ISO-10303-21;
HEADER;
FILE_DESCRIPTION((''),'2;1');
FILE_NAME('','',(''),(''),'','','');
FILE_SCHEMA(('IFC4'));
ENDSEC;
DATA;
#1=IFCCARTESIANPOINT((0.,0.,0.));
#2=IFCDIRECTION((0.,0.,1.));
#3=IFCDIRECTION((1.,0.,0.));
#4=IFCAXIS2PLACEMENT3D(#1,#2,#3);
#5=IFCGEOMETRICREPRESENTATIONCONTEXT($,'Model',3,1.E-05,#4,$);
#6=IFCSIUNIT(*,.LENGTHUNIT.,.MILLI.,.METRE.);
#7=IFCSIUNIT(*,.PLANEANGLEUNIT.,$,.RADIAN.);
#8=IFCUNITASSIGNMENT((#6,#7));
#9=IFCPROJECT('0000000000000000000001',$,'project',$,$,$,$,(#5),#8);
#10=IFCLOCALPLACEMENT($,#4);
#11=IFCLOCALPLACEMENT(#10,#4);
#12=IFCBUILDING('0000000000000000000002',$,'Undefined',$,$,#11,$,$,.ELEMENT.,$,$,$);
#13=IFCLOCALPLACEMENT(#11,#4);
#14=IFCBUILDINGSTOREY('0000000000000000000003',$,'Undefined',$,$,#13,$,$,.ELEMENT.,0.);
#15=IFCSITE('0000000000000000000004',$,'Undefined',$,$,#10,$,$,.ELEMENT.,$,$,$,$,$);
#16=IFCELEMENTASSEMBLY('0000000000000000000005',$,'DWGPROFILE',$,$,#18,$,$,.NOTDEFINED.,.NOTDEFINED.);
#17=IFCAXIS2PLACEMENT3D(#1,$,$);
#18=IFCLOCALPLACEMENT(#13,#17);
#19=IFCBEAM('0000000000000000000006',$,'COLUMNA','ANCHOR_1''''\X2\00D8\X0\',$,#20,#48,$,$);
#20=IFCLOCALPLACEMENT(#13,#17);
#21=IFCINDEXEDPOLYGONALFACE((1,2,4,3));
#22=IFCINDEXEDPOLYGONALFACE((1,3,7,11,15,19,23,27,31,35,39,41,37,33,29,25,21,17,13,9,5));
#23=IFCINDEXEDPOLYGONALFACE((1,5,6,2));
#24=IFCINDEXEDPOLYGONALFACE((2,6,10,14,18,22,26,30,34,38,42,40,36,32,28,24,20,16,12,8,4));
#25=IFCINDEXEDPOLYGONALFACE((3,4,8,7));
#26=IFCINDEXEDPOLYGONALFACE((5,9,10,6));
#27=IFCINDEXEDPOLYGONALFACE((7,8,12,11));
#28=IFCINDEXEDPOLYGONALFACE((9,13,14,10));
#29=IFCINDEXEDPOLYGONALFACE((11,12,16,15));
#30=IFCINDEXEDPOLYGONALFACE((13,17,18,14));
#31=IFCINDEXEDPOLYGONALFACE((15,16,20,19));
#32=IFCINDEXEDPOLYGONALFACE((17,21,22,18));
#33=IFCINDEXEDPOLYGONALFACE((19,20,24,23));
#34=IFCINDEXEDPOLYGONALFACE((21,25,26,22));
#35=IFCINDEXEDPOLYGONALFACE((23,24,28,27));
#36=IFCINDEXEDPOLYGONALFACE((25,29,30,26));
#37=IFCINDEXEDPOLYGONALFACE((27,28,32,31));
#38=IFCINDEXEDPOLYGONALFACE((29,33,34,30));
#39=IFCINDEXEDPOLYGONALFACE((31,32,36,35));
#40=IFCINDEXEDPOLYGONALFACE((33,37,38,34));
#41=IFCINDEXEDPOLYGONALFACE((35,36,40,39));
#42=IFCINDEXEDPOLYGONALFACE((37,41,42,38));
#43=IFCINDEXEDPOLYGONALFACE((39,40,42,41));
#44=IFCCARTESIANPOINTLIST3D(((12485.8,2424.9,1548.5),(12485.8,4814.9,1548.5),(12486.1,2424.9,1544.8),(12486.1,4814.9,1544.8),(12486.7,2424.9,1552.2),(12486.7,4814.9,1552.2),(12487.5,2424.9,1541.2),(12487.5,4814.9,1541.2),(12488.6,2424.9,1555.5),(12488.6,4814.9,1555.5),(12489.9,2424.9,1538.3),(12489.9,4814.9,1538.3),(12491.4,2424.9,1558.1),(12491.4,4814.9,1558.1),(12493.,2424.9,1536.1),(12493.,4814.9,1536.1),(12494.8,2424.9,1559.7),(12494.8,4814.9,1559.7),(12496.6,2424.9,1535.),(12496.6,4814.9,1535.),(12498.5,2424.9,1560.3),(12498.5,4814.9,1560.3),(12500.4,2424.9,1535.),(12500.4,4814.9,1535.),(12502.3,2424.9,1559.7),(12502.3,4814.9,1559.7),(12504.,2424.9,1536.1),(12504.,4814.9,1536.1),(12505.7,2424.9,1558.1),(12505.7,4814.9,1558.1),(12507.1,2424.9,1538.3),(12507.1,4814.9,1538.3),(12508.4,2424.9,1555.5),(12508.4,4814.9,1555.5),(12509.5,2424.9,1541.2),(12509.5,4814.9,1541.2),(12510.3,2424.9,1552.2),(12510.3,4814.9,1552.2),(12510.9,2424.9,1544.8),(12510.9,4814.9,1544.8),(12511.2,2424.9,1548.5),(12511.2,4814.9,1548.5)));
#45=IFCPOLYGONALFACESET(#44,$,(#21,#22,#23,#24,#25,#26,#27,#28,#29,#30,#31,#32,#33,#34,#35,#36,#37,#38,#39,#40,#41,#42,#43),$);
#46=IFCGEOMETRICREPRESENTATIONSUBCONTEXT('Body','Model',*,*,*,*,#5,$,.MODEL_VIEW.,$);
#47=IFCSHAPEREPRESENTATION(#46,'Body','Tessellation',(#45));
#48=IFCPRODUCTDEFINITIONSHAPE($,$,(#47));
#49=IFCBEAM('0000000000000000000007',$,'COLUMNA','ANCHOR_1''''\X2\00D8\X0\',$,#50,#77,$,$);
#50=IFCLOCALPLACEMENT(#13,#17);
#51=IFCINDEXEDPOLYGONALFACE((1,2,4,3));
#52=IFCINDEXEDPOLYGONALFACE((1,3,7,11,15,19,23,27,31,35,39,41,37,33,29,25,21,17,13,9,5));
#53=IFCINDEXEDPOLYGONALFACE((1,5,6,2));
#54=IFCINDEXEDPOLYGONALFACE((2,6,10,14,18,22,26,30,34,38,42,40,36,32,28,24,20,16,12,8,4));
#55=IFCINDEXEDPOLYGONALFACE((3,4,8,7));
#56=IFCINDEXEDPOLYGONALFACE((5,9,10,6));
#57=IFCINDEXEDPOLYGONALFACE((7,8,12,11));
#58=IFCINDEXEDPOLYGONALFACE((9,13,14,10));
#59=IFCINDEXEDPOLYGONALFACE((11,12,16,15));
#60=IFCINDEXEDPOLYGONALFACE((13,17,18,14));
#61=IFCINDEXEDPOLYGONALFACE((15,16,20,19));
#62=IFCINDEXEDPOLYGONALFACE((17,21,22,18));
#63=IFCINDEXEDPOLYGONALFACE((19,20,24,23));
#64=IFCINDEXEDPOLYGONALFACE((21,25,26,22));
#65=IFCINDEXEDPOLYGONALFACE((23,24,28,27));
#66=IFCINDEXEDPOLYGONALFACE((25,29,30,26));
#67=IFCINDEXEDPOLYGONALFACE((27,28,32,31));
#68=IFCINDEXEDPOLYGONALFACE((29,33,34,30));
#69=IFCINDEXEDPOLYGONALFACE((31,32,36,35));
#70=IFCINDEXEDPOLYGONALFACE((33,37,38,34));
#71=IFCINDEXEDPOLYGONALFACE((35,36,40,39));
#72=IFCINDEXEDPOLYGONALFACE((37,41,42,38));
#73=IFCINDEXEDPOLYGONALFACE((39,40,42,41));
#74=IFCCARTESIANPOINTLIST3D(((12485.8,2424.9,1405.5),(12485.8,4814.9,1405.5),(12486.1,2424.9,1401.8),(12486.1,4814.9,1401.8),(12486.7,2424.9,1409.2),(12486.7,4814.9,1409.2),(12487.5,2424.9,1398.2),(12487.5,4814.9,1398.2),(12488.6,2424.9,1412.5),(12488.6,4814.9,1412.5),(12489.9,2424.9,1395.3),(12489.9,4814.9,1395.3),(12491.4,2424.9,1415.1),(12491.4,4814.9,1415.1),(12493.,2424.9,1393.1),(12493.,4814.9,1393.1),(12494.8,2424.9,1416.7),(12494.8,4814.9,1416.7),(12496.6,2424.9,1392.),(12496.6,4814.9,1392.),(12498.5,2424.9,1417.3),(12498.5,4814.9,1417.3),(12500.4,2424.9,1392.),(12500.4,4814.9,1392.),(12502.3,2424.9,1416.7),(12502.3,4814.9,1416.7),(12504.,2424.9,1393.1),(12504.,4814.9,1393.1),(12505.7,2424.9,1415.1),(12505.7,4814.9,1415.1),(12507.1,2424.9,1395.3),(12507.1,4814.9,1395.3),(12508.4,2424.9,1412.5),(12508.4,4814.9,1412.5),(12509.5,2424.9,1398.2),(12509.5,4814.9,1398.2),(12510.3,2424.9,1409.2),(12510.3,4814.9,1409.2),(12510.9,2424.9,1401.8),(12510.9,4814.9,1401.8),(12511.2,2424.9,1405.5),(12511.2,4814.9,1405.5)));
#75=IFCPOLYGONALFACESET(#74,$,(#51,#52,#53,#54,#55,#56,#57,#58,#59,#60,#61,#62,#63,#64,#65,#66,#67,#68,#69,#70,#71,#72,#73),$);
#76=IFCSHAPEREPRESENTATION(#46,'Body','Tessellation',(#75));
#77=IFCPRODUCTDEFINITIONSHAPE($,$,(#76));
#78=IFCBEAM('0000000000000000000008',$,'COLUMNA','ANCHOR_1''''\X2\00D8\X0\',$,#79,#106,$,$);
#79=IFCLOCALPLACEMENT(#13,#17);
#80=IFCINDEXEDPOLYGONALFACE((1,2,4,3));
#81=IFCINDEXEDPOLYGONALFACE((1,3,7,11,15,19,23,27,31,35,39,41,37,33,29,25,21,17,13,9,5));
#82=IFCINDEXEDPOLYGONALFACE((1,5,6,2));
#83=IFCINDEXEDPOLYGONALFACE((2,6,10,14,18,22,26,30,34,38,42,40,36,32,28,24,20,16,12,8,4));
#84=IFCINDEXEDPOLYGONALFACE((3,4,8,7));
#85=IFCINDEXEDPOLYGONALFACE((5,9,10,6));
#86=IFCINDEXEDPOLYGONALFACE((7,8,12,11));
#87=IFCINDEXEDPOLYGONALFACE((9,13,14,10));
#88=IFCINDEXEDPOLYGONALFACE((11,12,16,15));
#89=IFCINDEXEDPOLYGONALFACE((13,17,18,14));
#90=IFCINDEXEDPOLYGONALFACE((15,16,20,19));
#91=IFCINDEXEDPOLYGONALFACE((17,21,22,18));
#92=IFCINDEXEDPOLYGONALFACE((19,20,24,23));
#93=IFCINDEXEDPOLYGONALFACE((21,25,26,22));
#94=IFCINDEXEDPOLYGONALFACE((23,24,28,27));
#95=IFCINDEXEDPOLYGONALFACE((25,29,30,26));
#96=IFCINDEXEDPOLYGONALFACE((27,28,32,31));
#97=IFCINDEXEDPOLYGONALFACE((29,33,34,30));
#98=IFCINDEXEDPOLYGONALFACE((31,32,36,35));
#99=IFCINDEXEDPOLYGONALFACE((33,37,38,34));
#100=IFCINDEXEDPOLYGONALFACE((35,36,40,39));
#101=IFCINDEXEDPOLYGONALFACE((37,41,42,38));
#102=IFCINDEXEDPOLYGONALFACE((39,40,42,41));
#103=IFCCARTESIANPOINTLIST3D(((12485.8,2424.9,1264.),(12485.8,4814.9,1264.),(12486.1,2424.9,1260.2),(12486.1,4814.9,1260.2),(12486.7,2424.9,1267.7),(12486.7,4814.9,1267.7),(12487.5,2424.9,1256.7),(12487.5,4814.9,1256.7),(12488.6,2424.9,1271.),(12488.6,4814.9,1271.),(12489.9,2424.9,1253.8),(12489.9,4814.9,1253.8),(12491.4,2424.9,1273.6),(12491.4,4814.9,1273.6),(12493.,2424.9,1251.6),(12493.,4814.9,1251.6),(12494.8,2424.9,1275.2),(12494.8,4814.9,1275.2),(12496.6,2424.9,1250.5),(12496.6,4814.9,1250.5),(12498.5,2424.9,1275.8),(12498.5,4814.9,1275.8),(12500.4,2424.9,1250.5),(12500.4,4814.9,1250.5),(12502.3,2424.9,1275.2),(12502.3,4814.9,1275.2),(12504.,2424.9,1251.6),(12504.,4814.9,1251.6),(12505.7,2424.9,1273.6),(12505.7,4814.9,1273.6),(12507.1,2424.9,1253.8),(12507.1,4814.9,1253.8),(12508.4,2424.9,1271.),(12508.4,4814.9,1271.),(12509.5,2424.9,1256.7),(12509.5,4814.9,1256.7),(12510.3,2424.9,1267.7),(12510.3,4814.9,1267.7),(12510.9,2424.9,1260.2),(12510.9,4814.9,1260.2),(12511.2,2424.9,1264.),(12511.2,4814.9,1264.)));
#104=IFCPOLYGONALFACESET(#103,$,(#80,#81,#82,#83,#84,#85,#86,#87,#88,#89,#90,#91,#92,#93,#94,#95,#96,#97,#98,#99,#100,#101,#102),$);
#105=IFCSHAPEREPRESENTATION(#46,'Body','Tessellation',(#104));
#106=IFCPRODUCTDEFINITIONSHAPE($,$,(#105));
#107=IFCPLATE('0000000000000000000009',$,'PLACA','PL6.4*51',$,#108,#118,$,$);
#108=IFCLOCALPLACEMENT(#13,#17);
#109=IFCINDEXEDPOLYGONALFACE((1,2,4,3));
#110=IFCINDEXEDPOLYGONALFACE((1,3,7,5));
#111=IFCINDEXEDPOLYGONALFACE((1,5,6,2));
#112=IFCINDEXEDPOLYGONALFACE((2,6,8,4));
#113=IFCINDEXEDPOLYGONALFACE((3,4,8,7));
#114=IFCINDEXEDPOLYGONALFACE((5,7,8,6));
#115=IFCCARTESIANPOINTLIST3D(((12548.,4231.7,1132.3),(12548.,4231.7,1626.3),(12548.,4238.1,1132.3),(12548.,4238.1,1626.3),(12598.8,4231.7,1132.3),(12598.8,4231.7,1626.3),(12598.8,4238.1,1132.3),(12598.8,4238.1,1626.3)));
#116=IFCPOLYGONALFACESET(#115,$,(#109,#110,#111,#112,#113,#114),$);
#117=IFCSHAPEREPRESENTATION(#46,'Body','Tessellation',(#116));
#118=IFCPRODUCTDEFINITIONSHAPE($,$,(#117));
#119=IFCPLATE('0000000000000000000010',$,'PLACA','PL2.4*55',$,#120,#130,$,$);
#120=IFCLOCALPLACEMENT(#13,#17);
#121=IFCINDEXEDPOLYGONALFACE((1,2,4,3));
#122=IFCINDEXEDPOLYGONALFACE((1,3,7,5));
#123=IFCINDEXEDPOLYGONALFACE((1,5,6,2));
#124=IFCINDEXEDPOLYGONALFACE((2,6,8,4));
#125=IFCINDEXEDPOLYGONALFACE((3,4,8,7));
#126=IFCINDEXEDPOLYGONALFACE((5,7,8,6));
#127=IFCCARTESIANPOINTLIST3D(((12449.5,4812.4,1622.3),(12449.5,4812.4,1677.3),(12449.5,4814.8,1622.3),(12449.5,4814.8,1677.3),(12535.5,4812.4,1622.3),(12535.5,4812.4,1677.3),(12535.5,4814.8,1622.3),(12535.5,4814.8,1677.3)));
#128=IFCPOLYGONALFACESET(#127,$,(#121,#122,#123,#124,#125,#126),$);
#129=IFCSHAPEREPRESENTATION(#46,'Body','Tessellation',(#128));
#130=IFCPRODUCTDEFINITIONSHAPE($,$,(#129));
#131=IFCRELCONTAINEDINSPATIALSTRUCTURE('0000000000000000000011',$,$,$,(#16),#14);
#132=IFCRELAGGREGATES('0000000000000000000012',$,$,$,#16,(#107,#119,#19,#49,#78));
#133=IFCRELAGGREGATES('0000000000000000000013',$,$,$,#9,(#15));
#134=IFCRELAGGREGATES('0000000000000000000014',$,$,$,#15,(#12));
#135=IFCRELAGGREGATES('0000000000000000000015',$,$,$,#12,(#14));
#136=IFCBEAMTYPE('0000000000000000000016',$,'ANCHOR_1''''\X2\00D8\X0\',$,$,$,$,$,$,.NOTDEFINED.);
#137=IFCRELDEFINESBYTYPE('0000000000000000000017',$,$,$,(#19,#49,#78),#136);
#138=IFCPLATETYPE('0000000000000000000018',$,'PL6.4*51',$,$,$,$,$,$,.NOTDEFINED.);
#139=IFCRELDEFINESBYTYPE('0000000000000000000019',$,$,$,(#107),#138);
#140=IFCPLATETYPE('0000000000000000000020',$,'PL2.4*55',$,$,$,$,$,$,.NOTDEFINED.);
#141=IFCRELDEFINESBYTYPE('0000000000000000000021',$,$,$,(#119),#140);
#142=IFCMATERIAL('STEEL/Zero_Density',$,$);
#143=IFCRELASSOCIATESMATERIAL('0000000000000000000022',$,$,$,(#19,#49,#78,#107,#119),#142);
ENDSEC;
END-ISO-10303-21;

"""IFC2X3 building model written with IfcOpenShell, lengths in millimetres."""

from ifc_helpers import new_model, si_unit, frame, origin_with_axes, origin_2d_with_axis, place, context, subcontext, project, spatial, polyline, circle, outline, extrude, material, type_object, element, aggregate, save


model = new_model("IFC2X3")

# Units and contexts
model_context = context("Model", 3, precision=1e-05, world=origin_with_axes())
body_context = subcontext(model_context, "Body", "Model", "MODEL_VIEW")
ifc_project = project(units=[si_unit("LENGTHUNIT", "METRE", prefix="MILLI"), si_unit("PLANEANGLEUNIT", "RADIAN")], contexts=[model_context])

# Site, building, storey
site_placement = place(None, origin_with_axes())
site = spatial("IfcSite", under=ifc_project, at=site_placement, Name="Undefined", CompositionType="ELEMENT")
building_placement = place(site_placement, origin_with_axes())
building = spatial("IfcBuilding", under=site, at=building_placement, Name="Undefined", CompositionType="ELEMENT")
storey_placement = place(building_placement, origin_with_axes())
storey = spatial("IfcBuildingStorey", under=building, at=storey_placement, Name="Undefined", CompositionType="ELEMENT", Elevation=0.0)

# Element assembly, beams, plates
assembly_1_placement = place(storey_placement, origin_with_axes())
assembly_1 = element("IfcElementAssembly", 1, at=assembly_1_placement, inside=storey, Name="DWGPROFILE", AssemblyPlace="NOTDEFINED", PredefinedType="NOTDEFINED")
ifc_material_1 = material(Name="STEEL/Zero_Density")
beam_type_1 = type_object("IfcBeamType", Name="ANCHOR_1''Ø", PredefinedType="NOTDEFINED")
beam_1_placement = place(assembly_1_placement, frame((12498.5, 4814.9, 1547.6), z_axis=(1.0, 0.0, 0.0), x_axis=(0.0, -1.0, 0.0)))
beam_1 = element("IfcBeam", 2, at=beam_1_placement, type_object=beam_type_1, material=ifc_material_1, Name="COLUMNA", Description="ANCHOR_1''Ø", context=body_context, shape_type="SweptSolid", body=[
    extrude(circle(Radius=12.7, at=origin_2d_with_axis()), frame((2390.0, 0.0, 0.0), z_axis=(-1.0, 0.0, 0.0), x_axis=(0.0, -1.0, 0.0)), (0.0, 0.0, 1.0), 2390.0),
])
beam_2_placement = place(assembly_1_placement, frame((12498.5, 4814.9, 1404.6), z_axis=(1.0, 0.0, 0.0), x_axis=(0.0, -1.0, 0.0)))
beam_2 = element("IfcBeam", 3, at=beam_2_placement, type_object=beam_type_1, material=ifc_material_1, Name="COLUMNA", Description="ANCHOR_1''Ø", context=body_context, shape_type="SweptSolid", body=[
    extrude(circle(Radius=12.7, at=origin_2d_with_axis()), frame((2390.0, 0.0, 0.0), z_axis=(-1.0, 0.0, 0.0), x_axis=(0.0, -1.0, 0.0)), (0.0, 0.0, 1.0), 2390.0),
])
beam_3_placement = place(assembly_1_placement, frame((12498.5, 4814.9, 1263.1), z_axis=(1.0, 0.0, 0.0), x_axis=(0.0, -1.0, 0.0)))
beam_3 = element("IfcBeam", 4, at=beam_3_placement, type_object=beam_type_1, material=ifc_material_1, Name="COLUMNA", Description="ANCHOR_1''Ø", context=body_context, shape_type="SweptSolid", body=[
    extrude(circle(Radius=12.7, at=origin_2d_with_axis()), frame((2390.0, 0.0, 0.0), z_axis=(-1.0, 0.0, 0.0), x_axis=(0.0, -1.0, 0.0)), (0.0, 0.0, 1.0), 2390.0),
])
plate_type_1 = type_object("IfcPlateType", Name="PL6.4*51", PredefinedType="NOTDEFINED")
plate_1_placement = place(assembly_1_placement, frame((12548.0, 4234.9, 1626.3), z_axis=(0.0, 1.0, 0.0), x_axis=(1.0, 0.0, 0.0)))
plate_1 = element("IfcPlate", 5, at=plate_1_placement, type_object=plate_type_1, material=ifc_material_1, Name="PLACA", Description="PL6.4*51", context=body_context, shape_type="SweptSolid", body=[
    extrude(outline(polyline([(0.0, 0.0), (50.8, 0.0), (50.8, 494.0), (0.0, 494.0), (0.0, 0.0)])), frame((0.0, 0.0, -3.2), z_axis=(0.0, 0.0, 1.0), x_axis=(1.0, 0.0, 0.0)), (0.0, 0.0, 1.0), 6.4),
])
plate_type_2 = type_object("IfcPlateType", Name="PL2.4*55", PredefinedType="NOTDEFINED")
plate_2_placement = place(assembly_1_placement, frame((12449.5, 4813.6, 1677.3), z_axis=(0.0, 1.0, 0.0), x_axis=(1.0, 0.0, 0.0)))
plate_2 = element("IfcPlate", 6, at=plate_2_placement, type_object=plate_type_2, material=ifc_material_1, Name="PLACA", Description="PL2.4*55", context=body_context, shape_type="SweptSolid", body=[
    extrude(outline(polyline([(0.0, 0.0), (86.0, 0.0), (86.0, 55.0), (0.0, 55.0), (0.0, 0.0)])), frame((0.0, 0.0, -1.2), z_axis=(0.0, 0.0, 1.0), x_axis=(1.0, 0.0, 0.0)), (0.0, 0.0, 1.0), 2.4),
])
aggregate(assembly_1, [plate_1, plate_2, beam_1, beam_2, beam_3])

save(model, "model.ifc")
